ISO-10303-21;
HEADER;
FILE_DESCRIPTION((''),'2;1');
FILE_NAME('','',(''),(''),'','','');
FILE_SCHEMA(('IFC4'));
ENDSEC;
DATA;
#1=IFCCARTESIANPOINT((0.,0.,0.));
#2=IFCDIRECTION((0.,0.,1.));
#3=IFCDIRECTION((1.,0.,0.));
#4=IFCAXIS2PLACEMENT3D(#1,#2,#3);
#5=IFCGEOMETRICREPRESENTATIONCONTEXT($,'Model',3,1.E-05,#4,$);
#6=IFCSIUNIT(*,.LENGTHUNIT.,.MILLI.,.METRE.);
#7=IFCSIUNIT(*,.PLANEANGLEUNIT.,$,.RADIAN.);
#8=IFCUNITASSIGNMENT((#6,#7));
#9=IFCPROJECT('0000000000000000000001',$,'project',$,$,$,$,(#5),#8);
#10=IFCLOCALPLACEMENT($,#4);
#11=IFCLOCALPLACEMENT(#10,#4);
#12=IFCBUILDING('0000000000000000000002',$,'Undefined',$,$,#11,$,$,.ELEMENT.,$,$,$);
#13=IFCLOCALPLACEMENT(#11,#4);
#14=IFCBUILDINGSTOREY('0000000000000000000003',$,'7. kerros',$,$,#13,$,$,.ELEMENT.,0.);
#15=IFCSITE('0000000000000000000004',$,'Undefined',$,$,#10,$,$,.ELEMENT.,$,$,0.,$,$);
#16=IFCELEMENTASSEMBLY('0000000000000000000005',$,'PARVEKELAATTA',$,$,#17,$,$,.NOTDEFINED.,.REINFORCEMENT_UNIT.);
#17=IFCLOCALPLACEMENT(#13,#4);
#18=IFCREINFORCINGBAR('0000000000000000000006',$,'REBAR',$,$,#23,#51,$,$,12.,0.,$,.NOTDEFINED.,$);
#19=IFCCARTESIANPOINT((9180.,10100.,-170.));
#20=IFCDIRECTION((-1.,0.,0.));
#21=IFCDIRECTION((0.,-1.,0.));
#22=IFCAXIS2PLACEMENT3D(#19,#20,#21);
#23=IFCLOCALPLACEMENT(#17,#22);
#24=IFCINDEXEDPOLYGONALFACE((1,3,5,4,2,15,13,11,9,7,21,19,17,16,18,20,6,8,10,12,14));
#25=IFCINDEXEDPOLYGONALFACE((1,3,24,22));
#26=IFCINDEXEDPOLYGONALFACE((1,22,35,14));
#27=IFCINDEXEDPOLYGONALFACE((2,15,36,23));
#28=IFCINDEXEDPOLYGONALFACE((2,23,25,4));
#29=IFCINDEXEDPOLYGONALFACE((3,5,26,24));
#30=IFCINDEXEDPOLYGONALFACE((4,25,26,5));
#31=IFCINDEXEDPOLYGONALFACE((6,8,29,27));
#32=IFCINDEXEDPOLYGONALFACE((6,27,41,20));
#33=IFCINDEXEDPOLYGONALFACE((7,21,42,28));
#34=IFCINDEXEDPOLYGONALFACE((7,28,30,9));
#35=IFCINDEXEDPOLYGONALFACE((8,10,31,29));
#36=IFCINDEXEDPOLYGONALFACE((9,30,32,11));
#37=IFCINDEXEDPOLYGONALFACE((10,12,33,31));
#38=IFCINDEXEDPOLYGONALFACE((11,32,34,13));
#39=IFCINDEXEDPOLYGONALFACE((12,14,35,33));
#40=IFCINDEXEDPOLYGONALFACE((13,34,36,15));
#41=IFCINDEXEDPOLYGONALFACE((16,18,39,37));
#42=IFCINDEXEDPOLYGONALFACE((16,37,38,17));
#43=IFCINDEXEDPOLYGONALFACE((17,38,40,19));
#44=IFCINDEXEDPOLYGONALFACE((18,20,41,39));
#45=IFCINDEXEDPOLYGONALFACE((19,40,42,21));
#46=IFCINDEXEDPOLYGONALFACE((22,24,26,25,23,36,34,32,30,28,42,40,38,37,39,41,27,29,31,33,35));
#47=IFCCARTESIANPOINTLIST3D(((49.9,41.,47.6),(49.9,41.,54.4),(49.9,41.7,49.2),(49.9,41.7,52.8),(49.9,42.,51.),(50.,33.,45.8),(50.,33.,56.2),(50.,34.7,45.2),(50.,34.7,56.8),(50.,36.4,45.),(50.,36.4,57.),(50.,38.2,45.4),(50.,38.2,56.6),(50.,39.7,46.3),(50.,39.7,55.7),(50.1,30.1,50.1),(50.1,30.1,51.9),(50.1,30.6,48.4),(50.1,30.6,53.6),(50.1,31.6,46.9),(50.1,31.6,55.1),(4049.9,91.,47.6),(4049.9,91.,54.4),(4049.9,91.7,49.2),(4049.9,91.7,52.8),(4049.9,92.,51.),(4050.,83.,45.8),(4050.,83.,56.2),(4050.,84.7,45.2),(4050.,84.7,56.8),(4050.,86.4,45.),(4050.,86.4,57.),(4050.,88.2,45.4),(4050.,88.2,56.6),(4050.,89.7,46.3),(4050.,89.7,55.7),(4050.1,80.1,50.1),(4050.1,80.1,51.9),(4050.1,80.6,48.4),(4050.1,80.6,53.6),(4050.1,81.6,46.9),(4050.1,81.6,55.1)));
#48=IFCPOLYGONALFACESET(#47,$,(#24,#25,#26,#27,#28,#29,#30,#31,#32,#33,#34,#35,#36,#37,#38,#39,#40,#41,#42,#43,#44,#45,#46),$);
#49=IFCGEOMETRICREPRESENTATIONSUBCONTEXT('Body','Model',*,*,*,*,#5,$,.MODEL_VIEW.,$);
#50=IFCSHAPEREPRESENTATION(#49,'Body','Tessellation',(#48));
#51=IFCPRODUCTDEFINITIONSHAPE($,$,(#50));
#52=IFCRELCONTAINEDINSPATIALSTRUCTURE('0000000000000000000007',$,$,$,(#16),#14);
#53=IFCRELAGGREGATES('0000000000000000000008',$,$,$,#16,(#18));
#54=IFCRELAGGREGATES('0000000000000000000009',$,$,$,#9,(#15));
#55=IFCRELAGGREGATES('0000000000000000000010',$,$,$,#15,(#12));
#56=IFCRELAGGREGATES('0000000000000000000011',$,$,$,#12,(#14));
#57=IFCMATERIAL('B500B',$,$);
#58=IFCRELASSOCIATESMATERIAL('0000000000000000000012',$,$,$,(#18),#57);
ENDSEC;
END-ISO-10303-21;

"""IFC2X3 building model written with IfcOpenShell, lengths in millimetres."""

from ifc_helpers import new_model, entity, si_unit, frame, origin_with_axes, place, context, subcontext, project, spatial, source, transform, mapped, material, element, aggregate, save


model = new_model("IFC2X3")

# Units and contexts
model_context = context("Model", 3, precision=1e-05, world=origin_with_axes())
body_context = subcontext(model_context, "Body", "Model", "MODEL_VIEW")
ifc_project = project(units=[si_unit("LENGTHUNIT", "METRE", prefix="MILLI"), si_unit("PLANEANGLEUNIT", "RADIAN")], contexts=[model_context])

# Site, building, storey
site_placement = place(None, origin_with_axes())
site = spatial("IfcSite", under=ifc_project, at=site_placement, Name="Undefined", CompositionType="ELEMENT", RefElevation=0.0)
building_placement = place(site_placement, origin_with_axes())
building = spatial("IfcBuilding", under=site, at=building_placement, Name="Undefined", CompositionType="ELEMENT")
storey_placement = place(building_placement, origin_with_axes())
storey = spatial("IfcBuildingStorey", under=building, at=storey_placement, Name="7. kerros", CompositionType="ELEMENT", Elevation=0.0)

# Element assembly, reinforcing bar
assembly_placement = place(storey_placement, origin_with_axes())
assembly = element("IfcElementAssembly", 1, at=assembly_placement, inside=storey, Name="PARVEKELAATTA", AssemblyPlace="NOTDEFINED", PredefinedType="REINFORCEMENT_UNIT")
ifc_material_1 = material(Name="B500B")
shared_shape_1 = source(origin_with_axes(), body_context, "Body", "AdvancedSweptSolid", [
    entity("IfcSweptDiskSolid", entity("IfcTrimmedCurve", entity("IfcLine", entity("IfcCartesianPoint", [0.0, 0.0, 0.0]), entity("IfcVector", entity("IfcDirection", [0.999922, 0.012499, 0.0]), 1.0)), [entity("IfcParameterValue", 0.0)], [entity("IfcParameterValue", 4000.312488)], True, "PARAMETER"), 6.0, None, 0.0, 4000.3),
])
reinforcing_bar_1_placement = place(assembly_placement, frame((9180.0, 10100.0, -170.0), z_axis=(-1.0, 0.0, 0.0), x_axis=(0.0, -1.0, 0.0)))
reinforcing_bar_1 = element("IfcReinforcingBar", 2, at=reinforcing_bar_1_placement, material=ifc_material_1, Name="REBAR", BarRole="NOTDEFINED", CrossSectionArea=0.0, NominalDiameter=12.0, context=body_context, shape_type="MappedRepresentation", body=[
    mapped(shared_shape_1, transform((50.0, 36.0, 51.0))),
])
aggregate(assembly, [reinforcing_bar_1])

save(model, "model.ifc")
